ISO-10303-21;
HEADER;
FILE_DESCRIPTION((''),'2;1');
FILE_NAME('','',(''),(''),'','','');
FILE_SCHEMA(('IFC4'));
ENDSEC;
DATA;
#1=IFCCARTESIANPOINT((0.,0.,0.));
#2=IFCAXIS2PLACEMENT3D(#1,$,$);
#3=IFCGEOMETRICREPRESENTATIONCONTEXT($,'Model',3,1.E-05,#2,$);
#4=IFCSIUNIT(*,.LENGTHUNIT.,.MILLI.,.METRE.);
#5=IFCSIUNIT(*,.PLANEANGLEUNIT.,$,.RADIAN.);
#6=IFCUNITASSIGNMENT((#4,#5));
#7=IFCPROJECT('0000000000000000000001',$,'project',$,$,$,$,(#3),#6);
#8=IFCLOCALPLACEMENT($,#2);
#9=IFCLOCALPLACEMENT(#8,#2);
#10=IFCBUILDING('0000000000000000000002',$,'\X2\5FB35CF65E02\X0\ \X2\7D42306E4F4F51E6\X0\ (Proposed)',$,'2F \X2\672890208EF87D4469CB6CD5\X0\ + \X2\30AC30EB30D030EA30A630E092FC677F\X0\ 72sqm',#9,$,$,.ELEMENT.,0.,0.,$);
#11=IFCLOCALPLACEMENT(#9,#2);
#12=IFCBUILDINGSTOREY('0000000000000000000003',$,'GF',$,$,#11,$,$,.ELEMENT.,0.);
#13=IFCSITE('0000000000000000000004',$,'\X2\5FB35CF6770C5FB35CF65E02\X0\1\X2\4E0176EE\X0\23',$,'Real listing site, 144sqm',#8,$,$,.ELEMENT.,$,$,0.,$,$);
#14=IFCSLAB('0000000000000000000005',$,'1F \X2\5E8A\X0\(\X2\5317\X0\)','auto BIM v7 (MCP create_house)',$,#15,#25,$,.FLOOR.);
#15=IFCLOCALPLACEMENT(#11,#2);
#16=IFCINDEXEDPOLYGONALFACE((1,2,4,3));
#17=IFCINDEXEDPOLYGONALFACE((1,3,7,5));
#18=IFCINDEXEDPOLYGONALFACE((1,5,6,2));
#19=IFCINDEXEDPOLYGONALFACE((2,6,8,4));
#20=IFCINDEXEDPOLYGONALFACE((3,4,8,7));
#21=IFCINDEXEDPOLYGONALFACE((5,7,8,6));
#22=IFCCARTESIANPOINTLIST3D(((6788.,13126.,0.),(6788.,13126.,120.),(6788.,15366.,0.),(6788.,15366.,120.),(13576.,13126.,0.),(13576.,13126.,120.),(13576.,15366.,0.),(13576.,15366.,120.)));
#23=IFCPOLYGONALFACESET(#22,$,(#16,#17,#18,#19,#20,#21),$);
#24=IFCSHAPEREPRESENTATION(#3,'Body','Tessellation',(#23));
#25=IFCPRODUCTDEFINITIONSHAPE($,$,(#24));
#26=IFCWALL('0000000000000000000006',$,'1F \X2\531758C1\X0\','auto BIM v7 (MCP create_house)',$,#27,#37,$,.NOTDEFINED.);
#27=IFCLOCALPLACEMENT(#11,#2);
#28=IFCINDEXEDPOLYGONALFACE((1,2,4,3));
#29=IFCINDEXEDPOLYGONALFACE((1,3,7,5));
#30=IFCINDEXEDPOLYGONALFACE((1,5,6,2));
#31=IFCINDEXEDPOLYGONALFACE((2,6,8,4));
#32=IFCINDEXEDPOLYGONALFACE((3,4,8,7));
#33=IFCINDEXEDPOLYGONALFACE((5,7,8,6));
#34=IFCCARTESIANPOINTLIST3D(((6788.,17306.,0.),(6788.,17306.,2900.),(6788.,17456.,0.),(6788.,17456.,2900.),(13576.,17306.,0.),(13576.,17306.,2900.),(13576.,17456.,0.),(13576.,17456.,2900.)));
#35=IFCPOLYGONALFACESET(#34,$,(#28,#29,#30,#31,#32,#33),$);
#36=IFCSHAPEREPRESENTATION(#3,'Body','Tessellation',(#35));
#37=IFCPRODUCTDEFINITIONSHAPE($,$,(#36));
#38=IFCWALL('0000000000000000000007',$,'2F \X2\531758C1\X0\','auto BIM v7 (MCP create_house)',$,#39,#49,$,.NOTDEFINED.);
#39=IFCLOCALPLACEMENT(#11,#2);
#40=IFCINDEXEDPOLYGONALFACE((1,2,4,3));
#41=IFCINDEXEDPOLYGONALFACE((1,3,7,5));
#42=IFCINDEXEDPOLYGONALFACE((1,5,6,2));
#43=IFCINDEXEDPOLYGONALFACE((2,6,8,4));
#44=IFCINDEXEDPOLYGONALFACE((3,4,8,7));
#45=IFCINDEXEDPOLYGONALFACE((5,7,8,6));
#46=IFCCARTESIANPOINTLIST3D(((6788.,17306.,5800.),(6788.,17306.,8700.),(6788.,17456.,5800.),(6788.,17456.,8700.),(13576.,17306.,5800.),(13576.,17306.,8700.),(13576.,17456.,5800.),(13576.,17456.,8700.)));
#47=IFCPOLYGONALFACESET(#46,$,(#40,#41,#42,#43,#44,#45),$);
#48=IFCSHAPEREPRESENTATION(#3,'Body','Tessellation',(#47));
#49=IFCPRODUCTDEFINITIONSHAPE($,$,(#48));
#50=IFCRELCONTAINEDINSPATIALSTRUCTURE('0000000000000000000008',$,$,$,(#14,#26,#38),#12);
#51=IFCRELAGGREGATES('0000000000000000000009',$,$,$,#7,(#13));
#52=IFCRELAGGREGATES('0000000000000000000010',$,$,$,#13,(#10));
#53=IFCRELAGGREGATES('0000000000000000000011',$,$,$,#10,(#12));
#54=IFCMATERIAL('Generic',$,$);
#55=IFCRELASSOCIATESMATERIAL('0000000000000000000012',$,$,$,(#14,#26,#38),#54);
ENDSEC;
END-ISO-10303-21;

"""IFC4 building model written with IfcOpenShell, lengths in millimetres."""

from ifc_helpers import new_model, si_unit, frame, frame_2d, origin, place, context, project, spatial, rectangle, extrude, material, element, save


model = new_model("IFC4")

# Units and contexts
model_context = context("Model", 3, precision=1e-05, world=origin())
ifc_project = project(units=[si_unit("LENGTHUNIT", "METRE", prefix="MILLI"), si_unit("PLANEANGLEUNIT", "RADIAN")], contexts=[model_context])

# Site, building, storey
site_placement = place(None, origin())
site = spatial("IfcSite", under=ifc_project, at=site_placement, Name="徳島県徳島市1丁目23", ObjectType="Real listing site, 144sqm", CompositionType="ELEMENT", RefElevation=0.0)
building_placement = place(site_placement, origin())
building = spatial("IfcBuilding", under=site, at=building_placement, Name="徳島市 終の住処 (Proposed)", ObjectType="2F 木造軸組構法 + ガルバリウム鋼板 72sqm", CompositionType="ELEMENT", ElevationOfRefHeight=0.0, ElevationOfTerrain=0.0)
storey_placement = place(building_placement, origin())
storey = spatial("IfcBuildingStorey", under=building, at=storey_placement, Name="GF", CompositionType="ELEMENT", Elevation=0.0)

# Slab
ifc_material = material(Name="Generic")
slab_1_placement = place(storey_placement, frame((3394.0, 6563.0, 0.0)))
element("IfcSlab", 1, at=slab_1_placement, inside=storey, material=ifc_material, Name="1F 床(北)", Description="auto BIM v7 (MCP create_house)", PredefinedType="FLOOR", context=model_context, shape_type="SweptSolid", body=[
    extrude(rectangle(XDim=6788.0, YDim=2240.0, at=frame_2d((3394.0, 1120.0))), frame((3394.0, 6563.0, 0.0)), (0.0, 0.0, 1.0), 120.0),
])

# Wall
wall_1_placement = place(storey_placement, frame((3394.0, 8653.0, 0.0)))
element("IfcWall", 2, at=wall_1_placement, inside=storey, material=ifc_material, Name="1F 北壁", Description="auto BIM v7 (MCP create_house)", PredefinedType="NOTDEFINED", context=model_context, shape_type="SweptSolid", body=[
    extrude(rectangle(XDim=6788.0, YDim=150.0, at=frame_2d((3394.0, 75.0))), frame((3394.0, 8653.0, 0.0)), (0.0, 0.0, 1.0), 2900.0),
])

# Wall
wall_2_placement = place(storey_placement, frame((3394.0, 8653.0, 2900.0)))
element("IfcWall", 3, at=wall_2_placement, inside=storey, material=ifc_material, Name="2F 北壁", Description="auto BIM v7 (MCP create_house)", PredefinedType="NOTDEFINED", context=model_context, shape_type="SweptSolid", body=[
    extrude(rectangle(XDim=6788.0, YDim=150.0, at=frame_2d((3394.0, 75.0))), frame((3394.0, 8653.0, 2900.0)), (0.0, 0.0, 1.0), 2900.0),
])

save(model, "model.ifc")
